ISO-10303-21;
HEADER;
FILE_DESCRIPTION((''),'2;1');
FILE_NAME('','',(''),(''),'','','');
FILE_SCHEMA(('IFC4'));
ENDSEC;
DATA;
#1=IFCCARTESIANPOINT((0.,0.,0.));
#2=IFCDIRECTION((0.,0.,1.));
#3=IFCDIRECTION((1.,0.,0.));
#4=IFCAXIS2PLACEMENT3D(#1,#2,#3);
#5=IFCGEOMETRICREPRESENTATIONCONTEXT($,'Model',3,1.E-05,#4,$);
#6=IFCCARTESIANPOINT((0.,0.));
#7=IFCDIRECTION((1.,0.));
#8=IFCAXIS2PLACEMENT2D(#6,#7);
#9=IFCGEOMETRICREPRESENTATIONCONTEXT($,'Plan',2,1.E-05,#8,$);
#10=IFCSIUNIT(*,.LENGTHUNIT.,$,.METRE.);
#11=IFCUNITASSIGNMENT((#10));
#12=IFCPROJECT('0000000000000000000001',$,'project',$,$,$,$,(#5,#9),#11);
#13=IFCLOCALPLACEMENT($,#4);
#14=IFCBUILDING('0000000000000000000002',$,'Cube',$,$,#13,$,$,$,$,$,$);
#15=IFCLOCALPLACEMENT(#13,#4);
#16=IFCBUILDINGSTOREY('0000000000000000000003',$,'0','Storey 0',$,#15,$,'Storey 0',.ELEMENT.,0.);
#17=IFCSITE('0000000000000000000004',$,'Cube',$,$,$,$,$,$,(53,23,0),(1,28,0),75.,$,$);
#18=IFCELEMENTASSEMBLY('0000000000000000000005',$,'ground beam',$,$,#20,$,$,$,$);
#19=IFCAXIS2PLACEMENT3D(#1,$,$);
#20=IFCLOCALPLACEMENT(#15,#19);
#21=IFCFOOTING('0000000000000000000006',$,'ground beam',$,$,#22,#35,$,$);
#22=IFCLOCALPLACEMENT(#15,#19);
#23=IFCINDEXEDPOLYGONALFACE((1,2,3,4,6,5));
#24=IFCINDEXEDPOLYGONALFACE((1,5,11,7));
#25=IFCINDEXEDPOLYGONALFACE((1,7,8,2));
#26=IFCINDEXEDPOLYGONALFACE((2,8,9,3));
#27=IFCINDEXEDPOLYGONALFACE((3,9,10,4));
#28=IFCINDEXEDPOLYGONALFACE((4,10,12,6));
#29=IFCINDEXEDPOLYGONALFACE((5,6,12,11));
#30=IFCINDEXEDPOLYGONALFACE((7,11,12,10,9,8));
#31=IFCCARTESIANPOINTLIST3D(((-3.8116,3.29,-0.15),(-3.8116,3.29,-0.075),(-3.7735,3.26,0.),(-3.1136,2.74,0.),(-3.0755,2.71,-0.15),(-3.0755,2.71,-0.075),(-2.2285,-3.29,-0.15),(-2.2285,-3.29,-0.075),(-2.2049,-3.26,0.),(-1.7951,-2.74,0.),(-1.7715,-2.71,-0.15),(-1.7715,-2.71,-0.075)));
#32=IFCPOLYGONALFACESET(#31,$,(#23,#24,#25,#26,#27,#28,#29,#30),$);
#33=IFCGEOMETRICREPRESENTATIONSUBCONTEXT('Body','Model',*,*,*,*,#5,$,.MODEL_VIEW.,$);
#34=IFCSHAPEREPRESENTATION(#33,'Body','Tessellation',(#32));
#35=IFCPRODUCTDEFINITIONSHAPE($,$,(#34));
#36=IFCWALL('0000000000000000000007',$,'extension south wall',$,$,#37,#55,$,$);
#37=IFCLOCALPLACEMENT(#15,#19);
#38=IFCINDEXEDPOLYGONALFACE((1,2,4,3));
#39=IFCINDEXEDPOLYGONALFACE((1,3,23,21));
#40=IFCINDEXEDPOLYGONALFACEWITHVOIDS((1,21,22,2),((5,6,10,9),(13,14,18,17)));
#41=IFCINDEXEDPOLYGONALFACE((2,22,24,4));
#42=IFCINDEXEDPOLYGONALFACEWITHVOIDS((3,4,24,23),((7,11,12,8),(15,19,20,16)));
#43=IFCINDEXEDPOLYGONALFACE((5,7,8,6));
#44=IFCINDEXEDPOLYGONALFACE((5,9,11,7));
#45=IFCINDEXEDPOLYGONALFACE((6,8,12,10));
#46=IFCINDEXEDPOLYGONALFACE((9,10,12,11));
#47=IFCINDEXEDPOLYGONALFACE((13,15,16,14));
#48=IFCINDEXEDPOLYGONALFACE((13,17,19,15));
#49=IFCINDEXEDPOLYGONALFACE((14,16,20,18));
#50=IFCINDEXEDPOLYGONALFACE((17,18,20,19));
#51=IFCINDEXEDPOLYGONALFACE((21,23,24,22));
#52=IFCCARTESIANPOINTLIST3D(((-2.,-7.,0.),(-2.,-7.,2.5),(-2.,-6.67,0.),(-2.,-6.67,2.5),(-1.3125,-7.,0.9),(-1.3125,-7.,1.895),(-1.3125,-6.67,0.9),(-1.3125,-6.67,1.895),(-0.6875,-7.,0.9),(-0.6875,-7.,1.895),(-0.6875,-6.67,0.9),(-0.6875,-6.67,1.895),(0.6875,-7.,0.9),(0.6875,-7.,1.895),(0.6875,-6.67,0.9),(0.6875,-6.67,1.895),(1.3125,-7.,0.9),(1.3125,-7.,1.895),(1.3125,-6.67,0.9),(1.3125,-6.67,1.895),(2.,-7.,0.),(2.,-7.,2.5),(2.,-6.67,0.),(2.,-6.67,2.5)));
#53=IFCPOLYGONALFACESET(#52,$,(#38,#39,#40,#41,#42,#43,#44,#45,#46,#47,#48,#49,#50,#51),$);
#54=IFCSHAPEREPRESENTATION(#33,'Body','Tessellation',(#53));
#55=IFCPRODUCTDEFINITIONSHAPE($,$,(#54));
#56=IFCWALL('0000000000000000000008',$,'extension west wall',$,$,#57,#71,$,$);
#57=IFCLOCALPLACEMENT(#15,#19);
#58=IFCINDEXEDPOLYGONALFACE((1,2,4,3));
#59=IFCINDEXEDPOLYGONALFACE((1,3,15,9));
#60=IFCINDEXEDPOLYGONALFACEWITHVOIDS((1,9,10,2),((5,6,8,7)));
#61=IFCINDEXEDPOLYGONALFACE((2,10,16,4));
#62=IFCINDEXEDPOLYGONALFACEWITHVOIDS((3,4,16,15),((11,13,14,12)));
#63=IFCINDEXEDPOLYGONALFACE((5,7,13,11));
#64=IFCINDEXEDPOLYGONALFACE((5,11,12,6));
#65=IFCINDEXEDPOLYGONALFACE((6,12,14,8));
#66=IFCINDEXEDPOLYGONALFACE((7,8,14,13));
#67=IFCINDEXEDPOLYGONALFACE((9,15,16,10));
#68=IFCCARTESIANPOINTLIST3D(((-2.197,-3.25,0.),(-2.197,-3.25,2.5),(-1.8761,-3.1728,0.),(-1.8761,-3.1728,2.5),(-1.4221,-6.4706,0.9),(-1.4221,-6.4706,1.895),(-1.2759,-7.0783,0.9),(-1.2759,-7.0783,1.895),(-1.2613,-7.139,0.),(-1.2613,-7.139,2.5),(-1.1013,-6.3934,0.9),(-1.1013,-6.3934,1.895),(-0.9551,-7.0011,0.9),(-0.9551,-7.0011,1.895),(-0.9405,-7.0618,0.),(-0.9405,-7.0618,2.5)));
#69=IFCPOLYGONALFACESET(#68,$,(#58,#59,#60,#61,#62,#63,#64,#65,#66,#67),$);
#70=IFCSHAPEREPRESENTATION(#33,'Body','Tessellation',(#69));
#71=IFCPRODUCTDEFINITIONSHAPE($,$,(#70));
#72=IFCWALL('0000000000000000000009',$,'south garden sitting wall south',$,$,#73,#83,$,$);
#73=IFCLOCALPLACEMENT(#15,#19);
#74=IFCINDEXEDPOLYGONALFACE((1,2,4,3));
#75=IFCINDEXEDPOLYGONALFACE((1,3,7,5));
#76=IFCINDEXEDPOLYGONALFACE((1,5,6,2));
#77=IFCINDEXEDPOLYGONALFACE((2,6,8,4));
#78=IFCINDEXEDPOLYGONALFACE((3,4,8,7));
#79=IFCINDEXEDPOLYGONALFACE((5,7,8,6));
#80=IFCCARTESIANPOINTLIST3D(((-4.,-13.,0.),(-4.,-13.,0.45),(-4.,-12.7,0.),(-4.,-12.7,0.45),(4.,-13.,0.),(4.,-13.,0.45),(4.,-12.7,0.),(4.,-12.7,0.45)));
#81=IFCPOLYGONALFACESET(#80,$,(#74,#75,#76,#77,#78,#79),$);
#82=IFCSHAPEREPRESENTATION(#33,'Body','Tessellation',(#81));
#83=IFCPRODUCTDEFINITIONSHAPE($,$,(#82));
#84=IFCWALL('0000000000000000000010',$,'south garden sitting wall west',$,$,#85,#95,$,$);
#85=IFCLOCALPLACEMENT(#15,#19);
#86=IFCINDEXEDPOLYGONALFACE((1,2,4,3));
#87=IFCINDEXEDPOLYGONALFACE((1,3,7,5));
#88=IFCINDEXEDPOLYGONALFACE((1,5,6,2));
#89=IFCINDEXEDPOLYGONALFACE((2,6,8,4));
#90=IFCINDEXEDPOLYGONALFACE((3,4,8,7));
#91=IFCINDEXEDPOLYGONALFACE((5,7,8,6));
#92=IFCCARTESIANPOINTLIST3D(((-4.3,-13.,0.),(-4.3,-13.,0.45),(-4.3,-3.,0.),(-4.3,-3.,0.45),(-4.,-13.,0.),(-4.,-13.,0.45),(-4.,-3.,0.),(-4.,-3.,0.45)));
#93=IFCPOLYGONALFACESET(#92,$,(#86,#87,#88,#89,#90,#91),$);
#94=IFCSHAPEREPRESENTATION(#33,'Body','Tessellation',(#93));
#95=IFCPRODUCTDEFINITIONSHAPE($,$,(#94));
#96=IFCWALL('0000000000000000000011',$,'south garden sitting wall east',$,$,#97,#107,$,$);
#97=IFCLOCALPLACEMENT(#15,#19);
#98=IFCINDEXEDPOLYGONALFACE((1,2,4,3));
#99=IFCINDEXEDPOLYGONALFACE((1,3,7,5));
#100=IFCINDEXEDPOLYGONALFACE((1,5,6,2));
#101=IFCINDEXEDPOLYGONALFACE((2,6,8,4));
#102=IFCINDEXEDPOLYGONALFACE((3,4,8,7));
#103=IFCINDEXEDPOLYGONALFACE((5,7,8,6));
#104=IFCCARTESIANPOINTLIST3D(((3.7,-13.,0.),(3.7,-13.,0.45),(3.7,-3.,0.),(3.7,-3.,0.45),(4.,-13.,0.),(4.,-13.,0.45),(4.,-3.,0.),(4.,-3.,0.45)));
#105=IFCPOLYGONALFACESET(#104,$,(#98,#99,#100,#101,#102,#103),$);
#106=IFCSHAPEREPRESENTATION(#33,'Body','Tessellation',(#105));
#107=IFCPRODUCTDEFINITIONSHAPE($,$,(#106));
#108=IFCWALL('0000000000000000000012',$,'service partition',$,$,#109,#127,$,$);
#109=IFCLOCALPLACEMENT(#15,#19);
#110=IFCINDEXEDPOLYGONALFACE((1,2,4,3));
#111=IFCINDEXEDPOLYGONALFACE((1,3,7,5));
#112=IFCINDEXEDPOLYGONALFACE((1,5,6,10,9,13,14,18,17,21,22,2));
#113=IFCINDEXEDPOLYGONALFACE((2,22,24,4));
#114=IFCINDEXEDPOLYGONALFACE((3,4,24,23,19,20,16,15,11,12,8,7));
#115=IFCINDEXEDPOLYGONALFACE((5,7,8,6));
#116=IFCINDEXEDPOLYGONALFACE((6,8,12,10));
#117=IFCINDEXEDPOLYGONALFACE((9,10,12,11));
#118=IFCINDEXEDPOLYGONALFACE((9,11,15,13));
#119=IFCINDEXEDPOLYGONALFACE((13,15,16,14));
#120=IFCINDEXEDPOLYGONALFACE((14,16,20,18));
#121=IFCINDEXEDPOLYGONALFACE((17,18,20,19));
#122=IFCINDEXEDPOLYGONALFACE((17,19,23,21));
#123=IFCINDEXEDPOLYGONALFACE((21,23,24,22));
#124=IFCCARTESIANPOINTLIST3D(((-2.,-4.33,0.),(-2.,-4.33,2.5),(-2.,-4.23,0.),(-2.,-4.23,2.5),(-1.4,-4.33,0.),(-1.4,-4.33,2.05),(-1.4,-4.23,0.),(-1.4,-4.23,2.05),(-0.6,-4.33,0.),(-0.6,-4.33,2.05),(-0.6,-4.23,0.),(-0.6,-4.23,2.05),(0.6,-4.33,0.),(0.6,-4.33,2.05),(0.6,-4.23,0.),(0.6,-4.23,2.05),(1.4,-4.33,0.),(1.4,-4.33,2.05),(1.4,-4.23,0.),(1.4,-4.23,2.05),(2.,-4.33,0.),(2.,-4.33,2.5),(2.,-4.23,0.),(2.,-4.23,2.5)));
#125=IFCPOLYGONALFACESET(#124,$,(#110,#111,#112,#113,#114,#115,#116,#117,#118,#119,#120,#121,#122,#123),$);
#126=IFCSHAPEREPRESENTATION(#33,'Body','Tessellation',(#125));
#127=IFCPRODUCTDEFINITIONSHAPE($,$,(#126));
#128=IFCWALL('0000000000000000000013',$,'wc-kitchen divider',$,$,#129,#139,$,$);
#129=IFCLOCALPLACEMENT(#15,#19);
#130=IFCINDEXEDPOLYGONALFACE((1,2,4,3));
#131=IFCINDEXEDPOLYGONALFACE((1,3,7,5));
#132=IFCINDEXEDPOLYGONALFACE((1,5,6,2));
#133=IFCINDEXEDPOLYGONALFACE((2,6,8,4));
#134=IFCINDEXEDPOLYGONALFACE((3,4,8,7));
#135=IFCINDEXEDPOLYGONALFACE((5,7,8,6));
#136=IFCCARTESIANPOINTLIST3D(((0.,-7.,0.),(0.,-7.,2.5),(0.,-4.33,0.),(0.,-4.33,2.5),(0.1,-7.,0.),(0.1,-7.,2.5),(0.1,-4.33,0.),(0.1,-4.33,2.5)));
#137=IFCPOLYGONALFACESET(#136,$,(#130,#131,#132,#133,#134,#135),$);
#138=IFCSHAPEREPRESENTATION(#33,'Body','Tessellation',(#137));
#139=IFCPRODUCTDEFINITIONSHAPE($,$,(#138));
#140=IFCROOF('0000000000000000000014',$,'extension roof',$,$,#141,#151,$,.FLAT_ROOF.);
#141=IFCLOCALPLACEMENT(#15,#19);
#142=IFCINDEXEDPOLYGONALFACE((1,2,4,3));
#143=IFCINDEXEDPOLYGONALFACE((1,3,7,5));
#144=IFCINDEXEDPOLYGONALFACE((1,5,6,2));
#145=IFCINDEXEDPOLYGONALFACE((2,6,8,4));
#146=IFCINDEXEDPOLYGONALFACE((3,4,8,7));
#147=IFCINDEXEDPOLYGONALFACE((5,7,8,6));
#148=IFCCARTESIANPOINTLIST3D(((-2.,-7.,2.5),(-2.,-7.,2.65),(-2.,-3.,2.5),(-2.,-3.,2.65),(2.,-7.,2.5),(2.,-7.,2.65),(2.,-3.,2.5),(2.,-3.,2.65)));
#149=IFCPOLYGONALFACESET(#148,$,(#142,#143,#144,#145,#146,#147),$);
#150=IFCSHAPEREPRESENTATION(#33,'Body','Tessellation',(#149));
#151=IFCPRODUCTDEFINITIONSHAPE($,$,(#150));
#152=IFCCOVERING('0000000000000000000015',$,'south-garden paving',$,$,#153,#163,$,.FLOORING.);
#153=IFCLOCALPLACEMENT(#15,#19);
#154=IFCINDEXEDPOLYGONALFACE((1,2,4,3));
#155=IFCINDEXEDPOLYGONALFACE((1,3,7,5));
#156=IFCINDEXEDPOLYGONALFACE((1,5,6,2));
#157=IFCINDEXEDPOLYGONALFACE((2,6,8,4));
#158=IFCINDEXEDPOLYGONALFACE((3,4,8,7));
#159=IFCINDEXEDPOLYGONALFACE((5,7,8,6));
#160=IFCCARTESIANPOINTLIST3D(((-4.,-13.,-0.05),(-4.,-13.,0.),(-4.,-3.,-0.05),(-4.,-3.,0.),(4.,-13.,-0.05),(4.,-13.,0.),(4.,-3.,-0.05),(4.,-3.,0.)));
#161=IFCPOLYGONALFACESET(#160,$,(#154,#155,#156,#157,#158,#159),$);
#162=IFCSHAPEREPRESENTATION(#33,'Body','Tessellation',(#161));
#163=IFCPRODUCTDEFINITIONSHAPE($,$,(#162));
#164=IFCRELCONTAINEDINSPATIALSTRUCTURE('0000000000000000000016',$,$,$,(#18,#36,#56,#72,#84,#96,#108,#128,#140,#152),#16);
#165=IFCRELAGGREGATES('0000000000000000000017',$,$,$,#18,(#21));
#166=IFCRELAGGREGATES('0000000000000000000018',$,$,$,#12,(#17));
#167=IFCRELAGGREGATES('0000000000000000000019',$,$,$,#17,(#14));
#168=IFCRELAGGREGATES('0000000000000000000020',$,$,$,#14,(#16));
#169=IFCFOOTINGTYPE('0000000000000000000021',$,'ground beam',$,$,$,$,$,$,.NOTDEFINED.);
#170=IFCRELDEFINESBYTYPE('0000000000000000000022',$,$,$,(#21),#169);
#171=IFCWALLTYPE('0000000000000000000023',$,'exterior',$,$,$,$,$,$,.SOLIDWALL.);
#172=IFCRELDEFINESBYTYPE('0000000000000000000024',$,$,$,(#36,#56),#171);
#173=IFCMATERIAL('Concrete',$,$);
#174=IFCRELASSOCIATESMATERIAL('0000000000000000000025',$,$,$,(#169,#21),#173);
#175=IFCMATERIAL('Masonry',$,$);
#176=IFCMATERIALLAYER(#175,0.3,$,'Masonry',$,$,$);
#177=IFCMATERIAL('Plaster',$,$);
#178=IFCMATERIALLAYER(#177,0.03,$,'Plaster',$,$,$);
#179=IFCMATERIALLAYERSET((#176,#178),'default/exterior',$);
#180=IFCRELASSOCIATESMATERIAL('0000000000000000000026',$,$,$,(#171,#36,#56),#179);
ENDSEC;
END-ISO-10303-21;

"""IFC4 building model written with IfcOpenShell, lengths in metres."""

from ifc_helpers import new_model, si_unit, frame, origin_with_axes, origin_2d_with_axis, place, context, subcontext, project, spatial, polyline, indexed_curve, outline, extrude, clip, halfspace, material, layer, layer_set, layer_usage, material_profile, profile_set, profile_usage, type_object, element, aggregate, save


model = new_model("IFC4")

# Units and contexts
model_context = context("Model", 3, precision=1e-05, world=origin_with_axes())
plan_context = context("Plan", 2, precision=1e-05, world=origin_2d_with_axis())
body_context_1 = subcontext(model_context, "Body", "Model", "MODEL_VIEW")
ifc_project = project(units=[si_unit("LENGTHUNIT", "METRE")], contexts=[model_context, plan_context])

# Site, building, storey
site = spatial("IfcSite", under=ifc_project, Name="Cube", RefLatitude=(53, 23, 0), RefLongitude=(1, 28, 0), RefElevation=75.0)
building_placement = place(None, origin_with_axes())
building = spatial("IfcBuilding", under=site, at=building_placement, Name="Cube")
storey_placement = place(building_placement, origin_with_axes())
storey = spatial("IfcBuildingStorey", under=building, at=storey_placement, Name="0", Description="Storey 0", LongName="Storey 0", CompositionType="ELEMENT", Elevation=0.0)

# Element assembly, footing
assembly_placement = place(storey_placement, origin_with_axes())
assembly = element("IfcElementAssembly", 1, at=assembly_placement, inside=storey, Name="ground beam")
ifc_material_1 = material(Name="Concrete")
ifc_material_profile = material_profile(ifc_material_1, outline(polyline([(-0.26, 0.0), (-0.29, -0.075), (-0.29, -0.15), (0.29, -0.15), (0.29, -0.075), (0.26, 0.0), (-0.26, 0.0)])))
ifc_profile_set = profile_set([ifc_material_profile])
ifc_profile_usage = profile_usage(ifc_profile_set)
footing_type = type_object("IfcFootingType", Name="ground beam", PredefinedType="NOTDEFINED", material=ifc_profile_set)
footing_placement = place(assembly_placement, frame((-1.7661, -3.9723, 0.0), z_axis=(-0.233915, 0.972257, 0.0), x_axis=(-0.972257, -0.233915, 0.0)))
footing = element("IfcFooting", 2, at=footing_placement, type_object=footing_type, material=ifc_profile_usage, Name="ground beam", context=body_context_1, shape_type="Clipping", body=[
    clip(clip(extrude(outline(polyline([(-0.26, 0.0), (-0.29, -0.075), (-0.29, -0.15), (0.29, -0.15), (0.29, -0.075), (0.26, 0.0), (-0.26, 0.0)])), origin_with_axes(), (0.0, 0.0, 1.0), 8.1712), halfspace(frame((0.0, 0.0, 1.0), z_axis=(-0.618904, 0.0, -0.785467), x_axis=(0.0, 1.0, 0.0)), False)), halfspace(frame((0.0, 0.0, 7.1712), z_axis=(-0.785467, 0.0, 0.618904), x_axis=(0.0, 1.0, 0.0)), False)),
])
aggregate(assembly, [footing])

# Wall, openings
ifc_material_2 = material(Name="Masonry")
ifc_layer_1 = layer(ifc_material_2, 0.3, Name="Masonry")
ifc_material_3 = material(Name="Plaster")
ifc_layer_2 = layer(ifc_material_3, 0.03, Name="Plaster")
ifc_layer_set = layer_set([ifc_layer_1, ifc_layer_2], Name="default/exterior")
ifc_layer_usage = layer_usage(ifc_layer_set, "AXIS2", "POSITIVE", 0.0)
wall_type = type_object("IfcWallType", Name="exterior", PredefinedType="SOLIDWALL", material=ifc_layer_set)
wall_1_placement = place(storey_placement, frame((-2.0, -7.0, 0.0), z_axis=(0.0, 0.0, 1.0), x_axis=(1.0, 0.0, 0.0)))
wall_1 = element("IfcWall", 3, at=wall_1_placement, inside=storey, type_object=wall_type, material=ifc_layer_usage, Name="extension south wall", context=body_context_1, shape_type="SweptSolid", body=[
    extrude(outline(indexed_curve([(0.0, 0.0), (0.0, 0.33), (4.0, 0.33), (4.0, 0.0), (0.0, 0.0)], self_intersect=False)), origin_with_axes(), (0.0, 0.0, 1.0), 2.5),
])
opening_1_placement = place(wall_1_placement, frame((0.6875, 0.0, 0.9), z_axis=(0.0, 0.0, 1.0), x_axis=(1.0, 0.0, 0.0)))
element("IfcOpeningElement", 4, at=opening_1_placement, cuts=wall_1, PredefinedType="OPENING", context=body_context_1, shape_type="SweptSolid", body=[
    extrude(outline(indexed_curve([(0.0, 0.0), (0.0, 0.5), (0.625, 0.5), (0.625, 0.0), (0.0, 0.0)], self_intersect=False)), origin_with_axes(), (0.0, 0.0, 1.0), 0.995),
])
opening_2_placement = place(wall_1_placement, frame((2.6875, 0.0, 0.9), z_axis=(0.0, 0.0, 1.0), x_axis=(1.0, 0.0, 0.0)))
element("IfcOpeningElement", 5, at=opening_2_placement, cuts=wall_1, PredefinedType="OPENING", context=body_context_1, shape_type="SweptSolid", body=[
    extrude(outline(indexed_curve([(0.0, 0.0), (0.0, 0.5), (0.625, 0.5), (0.625, 0.0), (0.0, 0.0)], self_intersect=False)), origin_with_axes(), (0.0, 0.0, 1.0), 0.995),
])

# Wall, opening
wall_2_placement = place(storey_placement, frame((-2.197, -3.25, 0.0), z_axis=(0.0, 0.0, 1.0), x_axis=(0.233916, -0.972257, 0.0)))
wall_2 = element("IfcWall", 6, at=wall_2_placement, inside=storey, type_object=wall_type, material=ifc_layer_usage, Name="extension west wall", context=body_context_1, shape_type="SweptSolid", body=[
    extrude(outline(indexed_curve([(0.0, 0.0), (0.0, 0.33), (4.0, 0.33), (4.0, 0.0), (0.0, 0.0)], self_intersect=False)), origin_with_axes(), (0.0, 0.0, 1.0), 2.5),
])
opening_3_placement = place(wall_2_placement, frame((3.3125, 0.0, 0.9), z_axis=(0.0, 0.0, 1.0), x_axis=(1.0, 0.0, 0.0)))
element("IfcOpeningElement", 7, at=opening_3_placement, cuts=wall_2, PredefinedType="OPENING", context=body_context_1, shape_type="SweptSolid", body=[
    extrude(outline(indexed_curve([(0.0, 0.0), (0.0, 0.5), (0.625, 0.5), (0.625, 0.0), (0.0, 0.0)], self_intersect=False)), origin_with_axes(), (0.0, 0.0, 1.0), 0.995),
])

# Walls
wall_3_placement = place(storey_placement, frame((-4.0, -13.0, 0.0), z_axis=(0.0, 0.0, 1.0), x_axis=(1.0, 0.0, 0.0)))
element("IfcWall", 8, at=wall_3_placement, inside=storey, Name="south garden sitting wall south", context=body_context_1, shape_type="SweptSolid", body=[
    extrude(outline(indexed_curve([(0.0, 0.0), (0.0, 0.3), (8.0, 0.3), (8.0, 0.0), (0.0, 0.0)], self_intersect=False)), origin_with_axes(), (0.0, 0.0, 1.0), 0.45),
])
for number, where, z_axis, x_axis, name in (
    (9, (-4.0, -13.0, 0.0), (0.0, 0.0, 1.0), (0.0, 1.0, 0.0), "south garden sitting wall west"),
    (10, (4.0, -13.0, 0.0), (0.0, 0.0, 1.0), (0.0, 1.0, 0.0), "south garden sitting wall east"),
):
    element("IfcWall", number, at=place(storey_placement, frame(where, z_axis=z_axis, x_axis=x_axis)), inside=storey, Name=name, context=body_context_1, shape_type="SweptSolid", body=[
        extrude(outline(indexed_curve([(0.0, 0.0), (0.0, 0.3), (10.0, 0.3), (10.0, 0.0), (0.0, 0.0)], self_intersect=False)), origin_with_axes(), (0.0, 0.0, 1.0), 0.45),
    ])

# Wall, openings
wall_4_placement = place(storey_placement, frame((-2.0, -4.33, 0.0), z_axis=(0.0, 0.0, 1.0), x_axis=(1.0, 0.0, 0.0)))
wall_4 = element("IfcWall", 11, at=wall_4_placement, inside=storey, Name="service partition", context=body_context_1, shape_type="SweptSolid", body=[
    extrude(outline(indexed_curve([(0.0, 0.0), (0.0, 0.1), (4.0, 0.1), (4.0, 0.0), (0.0, 0.0)], self_intersect=False)), origin_with_axes(), (0.0, 0.0, 1.0), 2.5),
])
opening_4_placement = place(wall_4_placement, frame((0.6, -0.05, 0.0), z_axis=(0.0, 0.0, 1.0), x_axis=(1.0, 0.0, 0.0)))
element("IfcOpeningElement", 12, at=opening_4_placement, cuts=wall_4, context=body_context_1, shape_type="SweptSolid", body=[
    extrude(outline(indexed_curve([(0.0, 0.0), (0.0, 0.3), (0.8, 0.3), (0.8, 0.0), (0.0, 0.0)], self_intersect=False)), origin_with_axes(), (0.0, 0.0, 1.0), 2.05),
])
opening_5_placement = place(wall_4_placement, frame((2.6, -0.05, 0.0), z_axis=(0.0, 0.0, 1.0), x_axis=(1.0, 0.0, 0.0)))
element("IfcOpeningElement", 13, at=opening_5_placement, cuts=wall_4, context=body_context_1, shape_type="SweptSolid", body=[
    extrude(outline(indexed_curve([(0.0, 0.0), (0.0, 0.3), (0.8, 0.3), (0.8, 0.0), (0.0, 0.0)], self_intersect=False)), origin_with_axes(), (0.0, 0.0, 1.0), 2.05),
])

# Wall
wall_5_placement = place(storey_placement, frame((0.0, -4.33, 0.0), z_axis=(0.0, 0.0, 1.0), x_axis=(0.0, -1.0, 0.0)))
element("IfcWall", 14, at=wall_5_placement, inside=storey, Name="wc-kitchen divider", context=body_context_1, shape_type="SweptSolid", body=[
    extrude(outline(indexed_curve([(0.0, 0.0), (0.0, 0.1), (2.67, 0.1), (2.67, 0.0), (0.0, 0.0)], self_intersect=False)), origin_with_axes(), (0.0, 0.0, 1.0), 2.5),
])

# Roof
roof_placement = place(storey_placement, frame((-2.0, -7.0, 2.5), z_axis=(0.0, 0.0, 1.0), x_axis=(1.0, 0.0, 0.0)))
element("IfcRoof", 15, at=roof_placement, inside=storey, Name="extension roof", PredefinedType="FLAT_ROOF", context=body_context_1, shape_type="SweptSolid", body=[
    extrude(outline(indexed_curve([(0.0, 0.0), (4.0, 0.0), (4.0, 4.0), (0.0, 4.0)])), None, (0.0, 0.0, 1.0), 0.15),
])

# Covering
covering_placement = place(storey_placement, frame((-4.0, -13.0, 0.0), z_axis=(0.0, 0.0, 1.0), x_axis=(1.0, 0.0, 0.0)))
element("IfcCovering", 16, at=covering_placement, inside=storey, Name="south-garden paving", PredefinedType="FLOORING", context=body_context_1, shape_type="SweptSolid", body=[
    extrude(outline(indexed_curve([(0.0, 0.0), (8.0, 0.0), (8.0, 10.0), (0.0, 10.0)])), None, (0.0, 0.0, -1.0), 0.05),
])

save(model, "model.ifc")
